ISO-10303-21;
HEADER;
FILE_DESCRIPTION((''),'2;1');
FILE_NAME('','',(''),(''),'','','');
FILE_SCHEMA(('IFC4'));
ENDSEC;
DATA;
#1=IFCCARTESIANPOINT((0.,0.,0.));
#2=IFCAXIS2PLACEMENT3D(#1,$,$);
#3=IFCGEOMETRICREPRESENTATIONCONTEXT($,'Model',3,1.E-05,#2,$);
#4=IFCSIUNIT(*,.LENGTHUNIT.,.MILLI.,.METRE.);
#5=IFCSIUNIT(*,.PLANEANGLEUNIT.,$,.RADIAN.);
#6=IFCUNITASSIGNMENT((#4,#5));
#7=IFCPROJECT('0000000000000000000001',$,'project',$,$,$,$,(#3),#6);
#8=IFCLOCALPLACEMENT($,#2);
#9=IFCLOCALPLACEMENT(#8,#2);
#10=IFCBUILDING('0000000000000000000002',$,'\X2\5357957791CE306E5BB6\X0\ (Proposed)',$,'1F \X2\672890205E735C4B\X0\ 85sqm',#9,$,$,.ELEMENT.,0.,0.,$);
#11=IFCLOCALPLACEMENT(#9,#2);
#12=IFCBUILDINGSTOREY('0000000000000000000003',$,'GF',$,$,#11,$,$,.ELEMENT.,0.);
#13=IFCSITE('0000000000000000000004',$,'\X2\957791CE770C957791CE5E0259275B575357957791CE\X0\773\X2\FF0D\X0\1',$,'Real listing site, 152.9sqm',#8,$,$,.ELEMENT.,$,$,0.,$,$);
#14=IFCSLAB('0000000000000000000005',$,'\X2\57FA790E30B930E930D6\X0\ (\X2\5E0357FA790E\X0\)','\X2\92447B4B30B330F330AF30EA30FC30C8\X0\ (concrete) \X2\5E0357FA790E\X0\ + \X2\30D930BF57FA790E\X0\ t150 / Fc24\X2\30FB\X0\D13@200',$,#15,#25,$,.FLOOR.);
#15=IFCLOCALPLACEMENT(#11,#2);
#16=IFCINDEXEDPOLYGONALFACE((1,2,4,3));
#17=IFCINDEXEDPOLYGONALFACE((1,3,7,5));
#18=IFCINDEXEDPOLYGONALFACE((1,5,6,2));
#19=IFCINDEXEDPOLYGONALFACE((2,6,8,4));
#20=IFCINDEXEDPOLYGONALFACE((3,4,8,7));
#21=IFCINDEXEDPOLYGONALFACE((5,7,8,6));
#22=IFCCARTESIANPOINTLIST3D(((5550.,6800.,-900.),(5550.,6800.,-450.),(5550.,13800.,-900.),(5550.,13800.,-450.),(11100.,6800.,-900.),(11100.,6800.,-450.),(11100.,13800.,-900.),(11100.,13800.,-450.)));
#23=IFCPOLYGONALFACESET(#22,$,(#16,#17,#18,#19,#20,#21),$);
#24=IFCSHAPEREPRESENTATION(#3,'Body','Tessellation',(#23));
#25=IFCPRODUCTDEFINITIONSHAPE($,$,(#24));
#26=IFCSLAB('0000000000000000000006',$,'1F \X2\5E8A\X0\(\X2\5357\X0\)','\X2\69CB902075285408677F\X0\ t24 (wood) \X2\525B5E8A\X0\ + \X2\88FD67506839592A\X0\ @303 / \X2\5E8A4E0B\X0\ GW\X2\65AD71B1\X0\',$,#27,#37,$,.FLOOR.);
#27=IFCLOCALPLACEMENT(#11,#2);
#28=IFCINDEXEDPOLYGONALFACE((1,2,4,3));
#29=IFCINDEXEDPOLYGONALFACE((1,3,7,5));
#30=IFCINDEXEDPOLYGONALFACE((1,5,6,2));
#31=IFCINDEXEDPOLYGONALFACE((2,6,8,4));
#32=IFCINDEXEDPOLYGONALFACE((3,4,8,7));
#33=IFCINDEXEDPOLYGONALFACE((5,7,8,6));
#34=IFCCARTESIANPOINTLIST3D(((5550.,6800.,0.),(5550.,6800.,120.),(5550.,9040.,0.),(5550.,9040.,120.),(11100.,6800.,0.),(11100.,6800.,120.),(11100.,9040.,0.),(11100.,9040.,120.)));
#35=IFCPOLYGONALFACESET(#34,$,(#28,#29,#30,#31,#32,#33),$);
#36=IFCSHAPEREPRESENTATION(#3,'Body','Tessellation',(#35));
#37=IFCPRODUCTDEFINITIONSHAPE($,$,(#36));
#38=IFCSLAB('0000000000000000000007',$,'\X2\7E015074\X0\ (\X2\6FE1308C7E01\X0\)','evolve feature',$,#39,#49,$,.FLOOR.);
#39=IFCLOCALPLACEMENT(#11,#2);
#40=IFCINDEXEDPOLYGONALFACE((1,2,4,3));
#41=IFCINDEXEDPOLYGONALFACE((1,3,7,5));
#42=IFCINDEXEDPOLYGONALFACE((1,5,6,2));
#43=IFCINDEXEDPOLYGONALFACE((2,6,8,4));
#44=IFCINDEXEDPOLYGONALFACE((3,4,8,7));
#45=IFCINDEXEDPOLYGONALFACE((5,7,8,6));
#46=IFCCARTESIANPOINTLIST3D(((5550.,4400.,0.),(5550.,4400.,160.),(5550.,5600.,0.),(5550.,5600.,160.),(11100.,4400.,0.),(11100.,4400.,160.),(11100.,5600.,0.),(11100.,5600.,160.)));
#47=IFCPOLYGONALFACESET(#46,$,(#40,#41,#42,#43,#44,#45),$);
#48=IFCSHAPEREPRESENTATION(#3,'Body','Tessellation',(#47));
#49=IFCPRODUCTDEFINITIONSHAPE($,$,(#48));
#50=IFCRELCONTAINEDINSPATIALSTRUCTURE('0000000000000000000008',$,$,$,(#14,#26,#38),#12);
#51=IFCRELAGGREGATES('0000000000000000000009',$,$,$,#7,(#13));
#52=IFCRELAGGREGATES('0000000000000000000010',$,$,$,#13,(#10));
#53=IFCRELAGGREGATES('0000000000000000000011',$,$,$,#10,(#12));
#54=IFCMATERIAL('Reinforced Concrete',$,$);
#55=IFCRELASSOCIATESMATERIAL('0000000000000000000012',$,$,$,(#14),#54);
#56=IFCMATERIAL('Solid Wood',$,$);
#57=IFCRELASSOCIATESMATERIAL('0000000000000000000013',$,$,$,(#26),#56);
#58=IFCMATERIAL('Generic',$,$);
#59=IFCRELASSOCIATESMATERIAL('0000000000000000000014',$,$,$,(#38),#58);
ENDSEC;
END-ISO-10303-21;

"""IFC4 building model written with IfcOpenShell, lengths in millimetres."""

from ifc_helpers import new_model, si_unit, frame, frame_2d, origin, place, context, project, spatial, rectangle, extrude, material, element, save


model = new_model("IFC4")

# Units and contexts
model_context = context("Model", 3, precision=1e-05, world=origin())
ifc_project = project(units=[si_unit("LENGTHUNIT", "METRE", prefix="MILLI"), si_unit("PLANEANGLEUNIT", "RADIAN")], contexts=[model_context])

# Site, building, storey
site_placement = place(None, origin())
site = spatial("IfcSite", under=ifc_project, at=site_placement, Name="長野県長野市大字南長野773－1", ObjectType="Real listing site, 152.9sqm", CompositionType="ELEMENT", RefElevation=0.0)
building_placement = place(site_placement, origin())
building = spatial("IfcBuilding", under=site, at=building_placement, Name="南長野の家 (Proposed)", ObjectType="1F 木造平屋 85sqm", CompositionType="ELEMENT", ElevationOfRefHeight=0.0, ElevationOfTerrain=0.0)
storey_placement = place(building_placement, origin())
storey = spatial("IfcBuildingStorey", under=building, at=storey_placement, Name="GF", CompositionType="ELEMENT", Elevation=0.0)

# Slabs
ifc_material_1 = material(Name="Reinforced Concrete")
slab_1_placement = place(storey_placement, frame((2775.0, 3400.0, -450.0)))
element("IfcSlab", 1, at=slab_1_placement, inside=storey, material=ifc_material_1, Name="基礎スラブ (布基礎)", Description="鉄筋コンクリート (concrete) 布基礎 + ベタ基礎 t150 / Fc24・D13@200", PredefinedType="FLOOR", context=model_context, shape_type="SweptSolid", body=[
    extrude(rectangle(XDim=5550.0, YDim=7000.0, at=frame_2d((2775.0, 3500.0))), frame((2775.0, 3400.0, -450.0)), (0.0, 0.0, 1.0), 450.0),
])
ifc_material_2 = material(Name="Solid Wood")
slab_2_placement = place(storey_placement, frame((2775.0, 3400.0, 0.0)))
element("IfcSlab", 2, at=slab_2_placement, inside=storey, material=ifc_material_2, Name="1F 床(南)", Description="構造用合板 t24 (wood) 剛床 + 製材根太 @303 / 床下 GW断熱", PredefinedType="FLOOR", context=model_context, shape_type="SweptSolid", body=[
    extrude(rectangle(XDim=5550.0, YDim=2240.0, at=frame_2d((2775.0, 1120.0))), frame((2775.0, 3400.0, 0.0)), (0.0, 0.0, 1.0), 120.0),
])
ifc_material_3 = material(Name="Generic")
slab_3_placement = place(storey_placement, frame((2775.0, 2200.0, 0.0)))
element("IfcSlab", 3, at=slab_3_placement, inside=storey, material=ifc_material_3, Name="縁側 (濡れ縁)", Description="evolve feature", PredefinedType="FLOOR", context=model_context, shape_type="SweptSolid", body=[
    extrude(rectangle(XDim=5550.0, YDim=1200.0, at=frame_2d((2775.0, 600.0))), frame((2775.0, 2200.0, 0.0)), (0.0, 0.0, 1.0), 160.0),
])

save(model, "model.ifc")
